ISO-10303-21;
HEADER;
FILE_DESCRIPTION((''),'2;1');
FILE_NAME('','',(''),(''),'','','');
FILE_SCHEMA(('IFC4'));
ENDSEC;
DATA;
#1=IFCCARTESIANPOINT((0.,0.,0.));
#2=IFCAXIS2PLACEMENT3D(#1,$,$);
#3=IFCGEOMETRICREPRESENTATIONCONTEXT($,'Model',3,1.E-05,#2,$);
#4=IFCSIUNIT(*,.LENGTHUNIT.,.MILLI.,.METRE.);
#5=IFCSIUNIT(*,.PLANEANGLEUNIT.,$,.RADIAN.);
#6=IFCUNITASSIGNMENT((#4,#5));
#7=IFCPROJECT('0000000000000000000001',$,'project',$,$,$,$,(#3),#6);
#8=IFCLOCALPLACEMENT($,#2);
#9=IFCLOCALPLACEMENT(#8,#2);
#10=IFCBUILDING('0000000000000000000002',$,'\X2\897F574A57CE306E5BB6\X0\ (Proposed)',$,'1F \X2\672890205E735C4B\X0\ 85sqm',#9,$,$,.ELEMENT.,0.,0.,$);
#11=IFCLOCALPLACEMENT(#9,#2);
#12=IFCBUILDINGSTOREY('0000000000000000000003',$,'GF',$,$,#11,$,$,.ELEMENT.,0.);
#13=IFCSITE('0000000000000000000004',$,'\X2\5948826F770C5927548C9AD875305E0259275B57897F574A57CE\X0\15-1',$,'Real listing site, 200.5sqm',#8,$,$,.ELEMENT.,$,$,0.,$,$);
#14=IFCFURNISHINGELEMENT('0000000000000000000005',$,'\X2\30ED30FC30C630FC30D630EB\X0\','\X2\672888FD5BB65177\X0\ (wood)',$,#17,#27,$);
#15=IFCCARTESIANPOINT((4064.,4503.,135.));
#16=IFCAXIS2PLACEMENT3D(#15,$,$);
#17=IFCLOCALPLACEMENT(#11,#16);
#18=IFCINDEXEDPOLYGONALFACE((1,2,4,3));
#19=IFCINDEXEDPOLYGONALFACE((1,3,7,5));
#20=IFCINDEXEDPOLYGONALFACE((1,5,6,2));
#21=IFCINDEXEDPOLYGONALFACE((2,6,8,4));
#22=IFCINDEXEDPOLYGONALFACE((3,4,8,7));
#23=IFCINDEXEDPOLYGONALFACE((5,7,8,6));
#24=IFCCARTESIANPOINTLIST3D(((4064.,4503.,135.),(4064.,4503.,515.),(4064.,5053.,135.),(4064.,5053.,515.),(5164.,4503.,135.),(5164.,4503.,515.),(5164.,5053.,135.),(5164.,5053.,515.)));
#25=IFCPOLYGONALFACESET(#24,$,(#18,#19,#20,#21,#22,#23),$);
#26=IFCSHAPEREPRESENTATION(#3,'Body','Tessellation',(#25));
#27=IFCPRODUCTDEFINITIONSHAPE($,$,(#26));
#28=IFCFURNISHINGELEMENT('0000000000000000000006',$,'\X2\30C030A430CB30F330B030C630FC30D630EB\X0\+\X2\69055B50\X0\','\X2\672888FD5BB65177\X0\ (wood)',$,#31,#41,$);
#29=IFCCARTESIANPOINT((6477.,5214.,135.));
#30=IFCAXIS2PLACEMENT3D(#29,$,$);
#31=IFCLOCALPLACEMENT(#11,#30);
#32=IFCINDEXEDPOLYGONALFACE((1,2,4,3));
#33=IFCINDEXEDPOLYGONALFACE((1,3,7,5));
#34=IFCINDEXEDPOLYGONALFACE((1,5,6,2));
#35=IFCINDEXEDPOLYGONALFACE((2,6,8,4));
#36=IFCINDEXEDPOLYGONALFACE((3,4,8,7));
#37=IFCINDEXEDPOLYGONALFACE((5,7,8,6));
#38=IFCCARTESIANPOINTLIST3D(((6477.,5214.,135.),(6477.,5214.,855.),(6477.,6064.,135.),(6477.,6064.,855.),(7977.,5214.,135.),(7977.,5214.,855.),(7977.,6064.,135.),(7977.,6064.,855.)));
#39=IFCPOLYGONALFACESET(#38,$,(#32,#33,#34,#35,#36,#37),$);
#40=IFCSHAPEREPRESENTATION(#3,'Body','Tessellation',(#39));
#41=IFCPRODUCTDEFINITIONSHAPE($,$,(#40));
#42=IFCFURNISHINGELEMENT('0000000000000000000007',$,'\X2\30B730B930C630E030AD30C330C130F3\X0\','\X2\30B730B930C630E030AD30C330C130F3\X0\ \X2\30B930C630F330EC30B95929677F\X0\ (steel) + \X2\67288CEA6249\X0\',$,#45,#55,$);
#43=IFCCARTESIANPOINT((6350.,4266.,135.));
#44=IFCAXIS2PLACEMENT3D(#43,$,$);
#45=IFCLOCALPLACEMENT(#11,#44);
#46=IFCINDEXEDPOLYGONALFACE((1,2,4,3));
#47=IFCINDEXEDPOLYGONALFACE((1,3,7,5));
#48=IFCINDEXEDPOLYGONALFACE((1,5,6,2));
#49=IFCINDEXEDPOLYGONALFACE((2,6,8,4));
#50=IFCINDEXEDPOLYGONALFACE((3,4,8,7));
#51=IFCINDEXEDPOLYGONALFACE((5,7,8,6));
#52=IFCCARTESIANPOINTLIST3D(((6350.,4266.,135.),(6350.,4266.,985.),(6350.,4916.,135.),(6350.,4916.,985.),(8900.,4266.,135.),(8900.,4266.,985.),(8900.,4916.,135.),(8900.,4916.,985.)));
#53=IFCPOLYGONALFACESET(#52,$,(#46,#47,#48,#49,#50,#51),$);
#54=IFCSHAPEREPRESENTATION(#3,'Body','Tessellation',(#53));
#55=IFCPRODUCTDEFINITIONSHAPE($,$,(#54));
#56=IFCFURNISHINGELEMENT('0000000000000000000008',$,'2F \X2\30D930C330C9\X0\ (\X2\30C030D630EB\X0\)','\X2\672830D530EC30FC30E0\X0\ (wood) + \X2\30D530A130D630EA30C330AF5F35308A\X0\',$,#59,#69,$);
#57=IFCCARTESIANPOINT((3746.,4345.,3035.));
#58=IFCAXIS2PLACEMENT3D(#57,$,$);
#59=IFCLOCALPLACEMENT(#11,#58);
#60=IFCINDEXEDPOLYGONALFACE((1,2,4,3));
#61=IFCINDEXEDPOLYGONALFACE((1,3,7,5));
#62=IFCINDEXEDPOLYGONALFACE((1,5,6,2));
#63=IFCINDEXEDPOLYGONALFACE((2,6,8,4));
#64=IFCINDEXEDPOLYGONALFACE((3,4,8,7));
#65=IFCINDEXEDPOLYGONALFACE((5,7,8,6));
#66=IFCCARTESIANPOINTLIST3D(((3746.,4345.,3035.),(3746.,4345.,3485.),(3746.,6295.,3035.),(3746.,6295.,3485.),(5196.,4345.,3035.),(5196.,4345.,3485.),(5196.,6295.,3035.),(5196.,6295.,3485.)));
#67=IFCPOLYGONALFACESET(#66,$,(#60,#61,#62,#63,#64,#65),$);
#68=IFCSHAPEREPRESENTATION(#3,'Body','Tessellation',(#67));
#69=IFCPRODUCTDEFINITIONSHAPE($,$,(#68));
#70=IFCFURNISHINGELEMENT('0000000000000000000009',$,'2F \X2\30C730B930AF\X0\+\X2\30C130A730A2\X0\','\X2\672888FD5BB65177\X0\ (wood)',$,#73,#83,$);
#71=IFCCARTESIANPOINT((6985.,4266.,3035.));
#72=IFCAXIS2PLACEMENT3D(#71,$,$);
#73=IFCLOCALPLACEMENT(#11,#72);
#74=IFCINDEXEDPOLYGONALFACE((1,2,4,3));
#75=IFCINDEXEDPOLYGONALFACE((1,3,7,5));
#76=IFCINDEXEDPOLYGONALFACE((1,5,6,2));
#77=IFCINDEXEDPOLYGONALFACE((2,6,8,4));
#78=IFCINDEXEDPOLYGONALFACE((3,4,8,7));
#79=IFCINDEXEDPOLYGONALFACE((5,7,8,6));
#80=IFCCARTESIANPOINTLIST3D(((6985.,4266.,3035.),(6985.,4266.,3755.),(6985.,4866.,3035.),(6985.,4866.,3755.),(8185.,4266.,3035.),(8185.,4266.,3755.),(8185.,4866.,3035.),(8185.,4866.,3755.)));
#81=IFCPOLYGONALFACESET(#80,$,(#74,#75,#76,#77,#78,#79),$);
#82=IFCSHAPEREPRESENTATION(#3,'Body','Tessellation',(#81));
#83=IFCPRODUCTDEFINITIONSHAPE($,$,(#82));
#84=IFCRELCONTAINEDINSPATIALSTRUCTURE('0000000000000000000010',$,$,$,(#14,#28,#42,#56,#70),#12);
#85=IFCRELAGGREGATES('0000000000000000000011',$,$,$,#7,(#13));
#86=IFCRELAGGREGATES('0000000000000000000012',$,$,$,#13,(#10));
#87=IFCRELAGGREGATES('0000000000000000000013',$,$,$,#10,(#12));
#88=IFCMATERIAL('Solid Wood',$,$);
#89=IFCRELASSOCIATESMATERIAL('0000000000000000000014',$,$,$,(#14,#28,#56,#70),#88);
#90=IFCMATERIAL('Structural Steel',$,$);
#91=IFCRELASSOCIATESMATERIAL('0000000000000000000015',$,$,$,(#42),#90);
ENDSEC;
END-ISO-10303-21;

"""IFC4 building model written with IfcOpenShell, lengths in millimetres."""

from ifc_helpers import new_model, si_unit, frame, frame_2d, origin, place, context, project, spatial, rectangle, extrude, material, element, save


model = new_model("IFC4")

# Units and contexts
model_context = context("Model", 3, precision=1e-05, world=origin())
ifc_project = project(units=[si_unit("LENGTHUNIT", "METRE", prefix="MILLI"), si_unit("PLANEANGLEUNIT", "RADIAN")], contexts=[model_context])

# Site, building, storey
site_placement = place(None, origin())
site = spatial("IfcSite", under=ifc_project, at=site_placement, Name="奈良県大和高田市大字西坊城15-1", ObjectType="Real listing site, 200.5sqm", CompositionType="ELEMENT", RefElevation=0.0)
building_placement = place(site_placement, origin())
building = spatial("IfcBuilding", under=site, at=building_placement, Name="西坊城の家 (Proposed)", ObjectType="1F 木造平屋 85sqm", CompositionType="ELEMENT", ElevationOfRefHeight=0.0, ElevationOfTerrain=0.0)
storey_placement = place(building_placement, origin())
storey = spatial("IfcBuildingStorey", under=building, at=storey_placement, Name="GF", CompositionType="ELEMENT", Elevation=0.0)

# Shared definitions
ifc_material_1 = material(Name="Solid Wood")

# Shared definitions
ifc_material_2 = material(Name="Structural Steel")

# Furnishing elements
furnishing_1_placement = place(storey_placement, frame((4064.0, 4503.0, 135.0)))
element("IfcFurnishingElement", 1, at=furnishing_1_placement, inside=storey, material=ifc_material_1, Name="ローテーブル", Description="木製家具 (wood)", context=model_context, shape_type="SweptSolid", body=[
    extrude(rectangle(XDim=1100.0, YDim=550.0, at=frame_2d((550.0, 275.0))), frame((4064.0, 4503.0, 135.0)), (0.0, 0.0, 1.0), 380.0),
])
furnishing_2_placement = place(storey_placement, frame((6477.0, 5214.0, 135.0)))
element("IfcFurnishingElement", 2, at=furnishing_2_placement, inside=storey, material=ifc_material_1, Name="ダイニングテーブル+椅子", Description="木製家具 (wood)", context=model_context, shape_type="SweptSolid", body=[
    extrude(rectangle(XDim=1500.0, YDim=850.0, at=frame_2d((750.0, 425.0))), frame((6477.0, 5214.0, 135.0)), (0.0, 0.0, 1.0), 720.0),
])
furnishing_3_placement = place(storey_placement, frame((6350.0, 4266.0, 135.0)))
element("IfcFurnishingElement", 3, at=furnishing_3_placement, inside=storey, material=ifc_material_2, Name="システムキッチン", Description="システムキッチン ステンレス天板 (steel) + 木質扉", context=model_context, shape_type="SweptSolid", body=[
    extrude(rectangle(XDim=2550.0, YDim=650.0, at=frame_2d((1275.0, 325.0))), frame((6350.0, 4266.0, 135.0)), (0.0, 0.0, 1.0), 850.0),
])
furnishing_4_placement = place(storey_placement, frame((3746.0, 4345.0, 3035.0)))
element("IfcFurnishingElement", 4, at=furnishing_4_placement, inside=storey, material=ifc_material_1, Name="2F ベッド (ダブル)", Description="木フレーム (wood) + ファブリック張り", context=model_context, shape_type="SweptSolid", body=[
    extrude(rectangle(XDim=1450.0, YDim=1950.0, at=frame_2d((725.0, 975.0))), frame((3746.0, 4345.0, 3035.0)), (0.0, 0.0, 1.0), 450.0),
])
furnishing_5_placement = place(storey_placement, frame((6985.0, 4266.0, 3035.0)))
element("IfcFurnishingElement", 5, at=furnishing_5_placement, inside=storey, material=ifc_material_1, Name="2F デスク+チェア", Description="木製家具 (wood)", context=model_context, shape_type="SweptSolid", body=[
    extrude(rectangle(XDim=1200.0, YDim=600.0, at=frame_2d((600.0, 300.0))), frame((6985.0, 4266.0, 3035.0)), (0.0, 0.0, 1.0), 720.0),
])

save(model, "model.ifc")
